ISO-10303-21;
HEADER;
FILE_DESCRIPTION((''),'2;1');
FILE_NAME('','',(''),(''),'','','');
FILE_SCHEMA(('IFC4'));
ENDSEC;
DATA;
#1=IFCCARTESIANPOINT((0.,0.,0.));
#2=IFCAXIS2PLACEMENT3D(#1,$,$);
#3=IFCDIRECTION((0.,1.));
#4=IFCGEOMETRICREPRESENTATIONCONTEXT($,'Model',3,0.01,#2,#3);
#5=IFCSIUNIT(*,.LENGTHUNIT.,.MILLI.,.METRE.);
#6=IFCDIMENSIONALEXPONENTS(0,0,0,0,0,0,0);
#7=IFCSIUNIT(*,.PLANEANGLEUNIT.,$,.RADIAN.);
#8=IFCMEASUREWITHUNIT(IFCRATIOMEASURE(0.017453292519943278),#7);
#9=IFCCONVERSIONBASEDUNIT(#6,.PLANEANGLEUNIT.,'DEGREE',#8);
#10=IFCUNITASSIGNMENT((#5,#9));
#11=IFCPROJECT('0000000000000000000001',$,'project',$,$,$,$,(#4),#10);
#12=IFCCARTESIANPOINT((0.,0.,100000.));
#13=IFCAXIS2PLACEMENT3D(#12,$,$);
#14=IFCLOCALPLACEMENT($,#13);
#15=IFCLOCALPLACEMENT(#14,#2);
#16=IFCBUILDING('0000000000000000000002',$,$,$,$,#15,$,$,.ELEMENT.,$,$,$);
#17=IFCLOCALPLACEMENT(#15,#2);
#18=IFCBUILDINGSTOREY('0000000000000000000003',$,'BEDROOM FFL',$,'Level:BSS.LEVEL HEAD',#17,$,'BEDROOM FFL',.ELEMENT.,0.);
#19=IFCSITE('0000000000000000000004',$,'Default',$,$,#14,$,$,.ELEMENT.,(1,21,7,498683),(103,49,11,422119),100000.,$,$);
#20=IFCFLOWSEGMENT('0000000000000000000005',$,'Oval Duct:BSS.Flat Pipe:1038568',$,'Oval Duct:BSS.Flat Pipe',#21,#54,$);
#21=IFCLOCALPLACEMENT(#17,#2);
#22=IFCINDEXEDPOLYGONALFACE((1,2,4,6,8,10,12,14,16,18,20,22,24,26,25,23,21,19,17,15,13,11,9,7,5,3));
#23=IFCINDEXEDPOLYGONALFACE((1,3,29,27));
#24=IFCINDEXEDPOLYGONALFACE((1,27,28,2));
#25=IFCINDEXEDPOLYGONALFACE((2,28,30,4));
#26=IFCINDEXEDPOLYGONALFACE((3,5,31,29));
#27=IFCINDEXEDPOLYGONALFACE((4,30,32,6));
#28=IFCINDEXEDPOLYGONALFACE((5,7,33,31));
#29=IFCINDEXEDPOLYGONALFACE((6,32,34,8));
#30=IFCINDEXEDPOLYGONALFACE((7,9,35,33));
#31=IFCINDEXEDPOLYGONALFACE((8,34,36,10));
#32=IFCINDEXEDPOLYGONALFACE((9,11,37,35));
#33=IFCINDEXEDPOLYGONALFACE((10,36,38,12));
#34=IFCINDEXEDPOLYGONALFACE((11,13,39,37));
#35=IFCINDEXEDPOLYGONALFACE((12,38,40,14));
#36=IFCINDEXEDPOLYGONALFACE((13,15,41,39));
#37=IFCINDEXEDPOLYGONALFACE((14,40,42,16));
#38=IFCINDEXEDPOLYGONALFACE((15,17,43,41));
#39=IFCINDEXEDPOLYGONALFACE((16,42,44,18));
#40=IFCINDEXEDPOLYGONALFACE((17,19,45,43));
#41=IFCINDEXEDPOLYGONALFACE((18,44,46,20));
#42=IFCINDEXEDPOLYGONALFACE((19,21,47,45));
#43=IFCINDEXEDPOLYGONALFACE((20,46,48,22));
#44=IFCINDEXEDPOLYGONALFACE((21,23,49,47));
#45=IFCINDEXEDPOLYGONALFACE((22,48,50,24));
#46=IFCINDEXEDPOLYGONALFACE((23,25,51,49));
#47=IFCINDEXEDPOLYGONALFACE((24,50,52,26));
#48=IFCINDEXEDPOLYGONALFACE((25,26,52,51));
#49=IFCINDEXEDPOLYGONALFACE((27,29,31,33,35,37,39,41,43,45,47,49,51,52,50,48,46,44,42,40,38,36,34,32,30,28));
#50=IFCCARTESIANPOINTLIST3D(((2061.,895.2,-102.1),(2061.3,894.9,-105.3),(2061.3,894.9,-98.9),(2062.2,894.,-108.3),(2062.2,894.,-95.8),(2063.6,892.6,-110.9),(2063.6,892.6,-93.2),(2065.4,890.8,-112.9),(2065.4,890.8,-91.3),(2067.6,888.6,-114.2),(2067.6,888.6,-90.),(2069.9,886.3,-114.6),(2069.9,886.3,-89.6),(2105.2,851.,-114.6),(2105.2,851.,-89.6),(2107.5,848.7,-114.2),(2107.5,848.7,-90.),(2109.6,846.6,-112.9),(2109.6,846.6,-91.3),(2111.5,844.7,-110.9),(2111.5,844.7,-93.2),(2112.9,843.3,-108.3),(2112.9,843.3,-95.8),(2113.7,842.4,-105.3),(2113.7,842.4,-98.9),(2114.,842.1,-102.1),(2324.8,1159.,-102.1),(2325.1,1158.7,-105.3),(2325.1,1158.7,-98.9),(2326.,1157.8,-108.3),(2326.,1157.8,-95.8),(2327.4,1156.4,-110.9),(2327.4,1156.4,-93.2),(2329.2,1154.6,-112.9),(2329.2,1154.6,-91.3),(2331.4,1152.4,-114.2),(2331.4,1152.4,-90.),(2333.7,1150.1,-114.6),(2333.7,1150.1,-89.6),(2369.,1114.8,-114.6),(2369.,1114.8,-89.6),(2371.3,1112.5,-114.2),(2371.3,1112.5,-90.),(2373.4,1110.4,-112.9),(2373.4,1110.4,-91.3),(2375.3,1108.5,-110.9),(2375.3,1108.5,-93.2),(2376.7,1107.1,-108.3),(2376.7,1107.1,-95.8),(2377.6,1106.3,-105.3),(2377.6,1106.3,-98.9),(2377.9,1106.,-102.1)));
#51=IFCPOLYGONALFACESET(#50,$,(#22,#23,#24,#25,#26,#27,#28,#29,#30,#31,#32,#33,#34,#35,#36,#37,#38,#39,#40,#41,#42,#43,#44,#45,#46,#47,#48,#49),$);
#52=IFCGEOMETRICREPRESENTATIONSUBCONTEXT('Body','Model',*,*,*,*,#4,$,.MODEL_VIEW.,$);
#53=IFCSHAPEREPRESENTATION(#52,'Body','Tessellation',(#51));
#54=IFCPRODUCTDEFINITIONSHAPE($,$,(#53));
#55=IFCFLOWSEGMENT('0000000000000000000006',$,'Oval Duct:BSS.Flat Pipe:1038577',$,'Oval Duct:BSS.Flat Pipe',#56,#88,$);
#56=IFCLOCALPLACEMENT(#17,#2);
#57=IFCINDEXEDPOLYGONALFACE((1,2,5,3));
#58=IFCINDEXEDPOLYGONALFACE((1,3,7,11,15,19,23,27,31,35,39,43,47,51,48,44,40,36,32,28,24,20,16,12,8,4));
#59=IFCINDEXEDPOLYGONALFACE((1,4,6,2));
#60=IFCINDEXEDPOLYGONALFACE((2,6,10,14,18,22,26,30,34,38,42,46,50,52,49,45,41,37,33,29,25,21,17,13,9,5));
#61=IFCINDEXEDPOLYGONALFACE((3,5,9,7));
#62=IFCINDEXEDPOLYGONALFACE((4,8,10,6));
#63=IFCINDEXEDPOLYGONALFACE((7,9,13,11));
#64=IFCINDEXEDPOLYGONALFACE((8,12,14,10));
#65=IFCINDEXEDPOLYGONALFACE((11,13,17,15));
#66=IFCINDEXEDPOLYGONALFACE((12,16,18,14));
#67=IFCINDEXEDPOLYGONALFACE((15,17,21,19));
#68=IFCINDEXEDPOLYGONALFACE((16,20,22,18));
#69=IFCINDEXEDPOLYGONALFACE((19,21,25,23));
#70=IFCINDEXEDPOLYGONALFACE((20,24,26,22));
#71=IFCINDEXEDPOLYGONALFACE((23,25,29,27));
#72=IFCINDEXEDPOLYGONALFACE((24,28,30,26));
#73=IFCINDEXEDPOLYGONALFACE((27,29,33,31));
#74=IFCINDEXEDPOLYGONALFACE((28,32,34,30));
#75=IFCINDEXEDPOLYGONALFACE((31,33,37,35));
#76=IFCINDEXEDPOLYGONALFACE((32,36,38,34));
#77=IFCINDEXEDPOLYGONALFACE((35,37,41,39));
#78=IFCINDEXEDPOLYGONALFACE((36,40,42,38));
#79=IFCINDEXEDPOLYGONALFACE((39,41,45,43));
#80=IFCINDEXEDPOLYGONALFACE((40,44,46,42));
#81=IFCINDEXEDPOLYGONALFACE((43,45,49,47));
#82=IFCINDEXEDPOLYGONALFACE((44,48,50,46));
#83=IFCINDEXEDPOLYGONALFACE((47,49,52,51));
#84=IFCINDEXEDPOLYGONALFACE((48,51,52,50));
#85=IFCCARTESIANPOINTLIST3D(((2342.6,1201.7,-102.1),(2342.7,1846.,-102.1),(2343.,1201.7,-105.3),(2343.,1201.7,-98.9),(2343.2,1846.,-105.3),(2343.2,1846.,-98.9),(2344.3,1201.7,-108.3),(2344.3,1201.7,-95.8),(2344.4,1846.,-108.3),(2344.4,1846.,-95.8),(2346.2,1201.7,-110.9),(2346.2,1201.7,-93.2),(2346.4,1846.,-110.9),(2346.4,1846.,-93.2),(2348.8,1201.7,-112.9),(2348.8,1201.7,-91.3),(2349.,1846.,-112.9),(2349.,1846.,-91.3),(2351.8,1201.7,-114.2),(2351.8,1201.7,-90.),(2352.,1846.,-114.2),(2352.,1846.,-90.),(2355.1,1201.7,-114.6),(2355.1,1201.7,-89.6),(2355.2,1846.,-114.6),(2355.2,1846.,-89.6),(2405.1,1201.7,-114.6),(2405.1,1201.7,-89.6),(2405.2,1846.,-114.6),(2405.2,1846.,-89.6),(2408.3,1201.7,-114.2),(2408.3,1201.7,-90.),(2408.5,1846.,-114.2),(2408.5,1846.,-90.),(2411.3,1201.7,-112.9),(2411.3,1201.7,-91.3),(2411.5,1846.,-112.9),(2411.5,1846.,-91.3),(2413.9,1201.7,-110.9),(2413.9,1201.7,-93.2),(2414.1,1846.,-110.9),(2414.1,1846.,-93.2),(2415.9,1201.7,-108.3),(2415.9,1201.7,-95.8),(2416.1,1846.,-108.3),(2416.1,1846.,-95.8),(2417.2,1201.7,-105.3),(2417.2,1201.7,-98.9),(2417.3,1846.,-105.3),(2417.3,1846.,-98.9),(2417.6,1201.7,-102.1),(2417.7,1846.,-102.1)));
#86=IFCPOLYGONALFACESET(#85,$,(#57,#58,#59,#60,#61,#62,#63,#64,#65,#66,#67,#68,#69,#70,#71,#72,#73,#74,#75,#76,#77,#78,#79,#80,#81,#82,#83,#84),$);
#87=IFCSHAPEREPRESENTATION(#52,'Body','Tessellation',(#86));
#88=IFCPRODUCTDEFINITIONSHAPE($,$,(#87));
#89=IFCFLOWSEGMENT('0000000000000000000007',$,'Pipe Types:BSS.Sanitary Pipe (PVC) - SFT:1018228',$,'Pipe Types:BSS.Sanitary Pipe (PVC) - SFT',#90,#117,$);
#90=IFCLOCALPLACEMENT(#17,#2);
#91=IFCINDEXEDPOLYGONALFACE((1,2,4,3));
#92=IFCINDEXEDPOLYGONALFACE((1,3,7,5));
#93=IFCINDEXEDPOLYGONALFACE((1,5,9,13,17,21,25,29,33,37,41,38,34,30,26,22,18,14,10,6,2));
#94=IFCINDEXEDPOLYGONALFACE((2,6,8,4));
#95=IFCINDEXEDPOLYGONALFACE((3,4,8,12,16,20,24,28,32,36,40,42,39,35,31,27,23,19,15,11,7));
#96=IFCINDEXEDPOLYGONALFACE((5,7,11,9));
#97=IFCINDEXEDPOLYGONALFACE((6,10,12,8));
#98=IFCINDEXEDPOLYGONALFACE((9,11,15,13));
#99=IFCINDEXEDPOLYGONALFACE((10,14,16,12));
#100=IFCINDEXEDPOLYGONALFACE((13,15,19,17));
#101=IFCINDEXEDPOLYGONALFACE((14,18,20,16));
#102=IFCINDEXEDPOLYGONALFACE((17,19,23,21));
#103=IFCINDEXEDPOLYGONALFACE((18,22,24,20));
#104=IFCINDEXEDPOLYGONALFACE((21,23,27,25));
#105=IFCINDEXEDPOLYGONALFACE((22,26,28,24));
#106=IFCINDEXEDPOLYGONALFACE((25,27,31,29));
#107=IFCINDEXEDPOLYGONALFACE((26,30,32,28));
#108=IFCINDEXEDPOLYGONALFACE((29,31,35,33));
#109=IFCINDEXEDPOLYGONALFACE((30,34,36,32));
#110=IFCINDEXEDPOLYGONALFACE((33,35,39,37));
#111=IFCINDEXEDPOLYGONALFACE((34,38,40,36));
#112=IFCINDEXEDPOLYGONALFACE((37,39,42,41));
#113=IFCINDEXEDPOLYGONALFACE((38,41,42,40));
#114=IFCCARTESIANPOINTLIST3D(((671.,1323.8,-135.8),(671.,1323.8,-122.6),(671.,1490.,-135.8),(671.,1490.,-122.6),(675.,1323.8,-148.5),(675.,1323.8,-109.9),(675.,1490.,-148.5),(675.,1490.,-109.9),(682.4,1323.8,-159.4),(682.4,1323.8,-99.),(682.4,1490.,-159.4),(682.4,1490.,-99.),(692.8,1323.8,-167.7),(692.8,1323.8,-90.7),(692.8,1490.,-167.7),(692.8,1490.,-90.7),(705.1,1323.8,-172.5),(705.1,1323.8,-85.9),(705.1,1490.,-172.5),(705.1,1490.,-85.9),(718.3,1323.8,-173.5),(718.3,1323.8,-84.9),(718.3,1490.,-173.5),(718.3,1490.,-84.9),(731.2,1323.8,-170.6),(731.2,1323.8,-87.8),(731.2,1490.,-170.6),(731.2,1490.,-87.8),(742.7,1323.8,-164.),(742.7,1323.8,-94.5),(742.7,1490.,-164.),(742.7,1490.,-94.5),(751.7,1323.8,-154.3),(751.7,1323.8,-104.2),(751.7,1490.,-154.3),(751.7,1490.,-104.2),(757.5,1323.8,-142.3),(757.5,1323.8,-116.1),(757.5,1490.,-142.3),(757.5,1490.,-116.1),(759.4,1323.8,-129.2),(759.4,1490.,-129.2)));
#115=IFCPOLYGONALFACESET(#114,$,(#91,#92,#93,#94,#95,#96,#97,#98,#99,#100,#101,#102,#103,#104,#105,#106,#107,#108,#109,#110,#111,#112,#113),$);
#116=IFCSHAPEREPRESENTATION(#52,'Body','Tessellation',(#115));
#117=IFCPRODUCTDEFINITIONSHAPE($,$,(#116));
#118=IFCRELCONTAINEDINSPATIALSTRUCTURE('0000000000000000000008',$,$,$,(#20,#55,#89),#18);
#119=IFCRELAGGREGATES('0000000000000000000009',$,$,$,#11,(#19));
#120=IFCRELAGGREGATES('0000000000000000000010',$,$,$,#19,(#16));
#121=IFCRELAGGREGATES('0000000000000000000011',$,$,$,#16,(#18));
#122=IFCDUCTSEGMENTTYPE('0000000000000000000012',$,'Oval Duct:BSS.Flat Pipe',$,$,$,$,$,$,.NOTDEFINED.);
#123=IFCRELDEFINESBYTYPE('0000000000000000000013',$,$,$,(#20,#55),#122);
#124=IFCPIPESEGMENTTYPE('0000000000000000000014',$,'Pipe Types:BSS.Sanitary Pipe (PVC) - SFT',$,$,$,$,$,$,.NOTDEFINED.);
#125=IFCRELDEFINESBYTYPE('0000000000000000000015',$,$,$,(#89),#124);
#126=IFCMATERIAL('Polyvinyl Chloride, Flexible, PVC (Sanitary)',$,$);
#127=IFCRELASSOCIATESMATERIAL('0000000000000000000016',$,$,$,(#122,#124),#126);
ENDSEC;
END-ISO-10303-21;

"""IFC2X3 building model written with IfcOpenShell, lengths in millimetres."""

from ifc_helpers import new_model, entity, si_unit, converted_unit, direction, frame, frame_2d, origin, place, context, subcontext, project, spatial, polyline, circle_curve, parameter, trimmed, segment, composite_curve, circle, outline, extrude, material, type_object, element, save


model = new_model("IFC2X3")

# Units and contexts
model_context = context("Model", 3, precision=0.01, world=origin(), true_north=direction((0.0, 1.0)))
body_context = subcontext(model_context, "Body", "Model", "MODEL_VIEW")
ifc_project = project(units=[si_unit("LENGTHUNIT", "METRE", prefix="MILLI"), converted_unit("PLANEANGLEUNIT", "DEGREE", entity("IfcRatioMeasure", 0.017453292519943278), si_unit("PLANEANGLEUNIT", "RADIAN"), dimensions=[0, 0, 0, 0, 0, 0, 0])], contexts=[model_context])

# Site, building, storey
site_placement = place(None, frame((0.0, 0.0, 100000.0)))
site = spatial("IfcSite", under=ifc_project, at=site_placement, Name="Default", CompositionType="ELEMENT", RefLatitude=(1, 21, 7, 498683), RefLongitude=(103, 49, 11, 422119), RefElevation=100000.0)
building_placement = place(site_placement, origin())
building = spatial("IfcBuilding", under=site, at=building_placement, CompositionType="ELEMENT")
storey_placement = place(building_placement, origin())
storey = spatial("IfcBuildingStorey", under=building, at=storey_placement, Name="BEDROOM FFL", ObjectType="Level:BSS.LEVEL HEAD", LongName="BEDROOM FFL", CompositionType="ELEMENT", Elevation=0.0)

# Flow segments
ifc_material_1 = material(Name="Polyvinyl Chloride, Flexible, PVC (Sanitary)")
duct_segment_type = type_object("IfcDuctSegmentType", Name="Oval Duct:BSS.Flat Pipe", PredefinedType="NOTDEFINED", material=ifc_material_1)
flow_segment_1_placement = place(storey_placement, origin())
element("IfcFlowSegment", 1, at=flow_segment_1_placement, inside=storey, type_object=duct_segment_type, Name="Oval Duct:BSS.Flat Pipe:1038568", ObjectType="Oval Duct:BSS.Flat Pipe", context=body_context, shape_type="SweptSolid", body=[
    extrude(outline(composite_curve([segment(trimmed(circle_curve(frame_2d((25.0, 0.0), x_axis=(1.0, 0.0)), 12.5), [parameter(270.0)], [parameter(0.0)], True, "PARAMETER"), True, "CONTINUOUS"), segment(trimmed(circle_curve(frame_2d((25.0, 0.0), x_axis=(1.0, 0.0)), 12.5), [parameter(0.0)], [parameter(90.0)], True, "PARAMETER"), True, "CONTINUOUS"), segment(polyline([(25.0, 12.5), (-25.0, 12.5)]), True, "CONTINUOUS"), segment(trimmed(circle_curve(frame_2d((-25.0, 0.0), x_axis=(1.0, 0.0)), 12.5), [parameter(90.0)], [parameter(180.0)], True, "PARAMETER"), True, "CONTINUOUS"), segment(trimmed(circle_curve(frame_2d((-25.0, 0.0), x_axis=(1.0, 0.0)), 12.5), [parameter(180.0)], [parameter(270.0)], True, "PARAMETER"), True, "CONTINUOUS"), segment(polyline([(-25.0, -12.5), (25.0, -12.5)]), True, "CONTINUOUS")], self_intersect=False)), frame((2087.5, 868.7, -102.1), z_axis=(0.707107, 0.707107, 0.0), x_axis=(0.707107, -0.707107, 0.0)), (0.0, 0.0, 1.0), 373.1),
])
flow_segment_2_placement = place(storey_placement, origin())
element("IfcFlowSegment", 2, at=flow_segment_2_placement, inside=storey, type_object=duct_segment_type, Name="Oval Duct:BSS.Flat Pipe:1038577", ObjectType="Oval Duct:BSS.Flat Pipe", context=body_context, shape_type="SweptSolid", body=[
    extrude(outline(composite_curve([segment(trimmed(circle_curve(frame_2d((25.0, 0.0), x_axis=(1.0, 0.0)), 12.5), [parameter(270.0)], [parameter(0.0)], True, "PARAMETER"), True, "CONTINUOUS"), segment(trimmed(circle_curve(frame_2d((25.0, 0.0), x_axis=(1.0, 0.0)), 12.5), [parameter(0.0)], [parameter(90.0)], True, "PARAMETER"), True, "CONTINUOUS"), segment(polyline([(25.0, 12.5), (-25.0, 12.5)]), True, "CONTINUOUS"), segment(trimmed(circle_curve(frame_2d((-25.0, 0.0), x_axis=(1.0, 0.0)), 12.5), [parameter(90.0)], [parameter(180.0)], True, "PARAMETER"), True, "CONTINUOUS"), segment(trimmed(circle_curve(frame_2d((-25.0, 0.0), x_axis=(1.0, 0.0)), 12.5), [parameter(180.0)], [parameter(270.0)], True, "PARAMETER"), True, "CONTINUOUS"), segment(polyline([(-25.0, -12.5), (25.0, -12.5)]), True, "CONTINUOUS")], self_intersect=False)), frame((2380.1, 1201.7, -102.1), z_axis=(0.000256, 1.0, 0.0), x_axis=(1.0, -0.000256, 0.0)), (0.0, 0.0, 1.0), 644.3),
])
pipe_segment_type_1 = type_object("IfcPipeSegmentType", Name="Pipe Types:BSS.Sanitary Pipe (PVC) - SFT", PredefinedType="NOTDEFINED", material=ifc_material_1)
flow_segment_3_placement = place(storey_placement, origin())
element("IfcFlowSegment", 3, at=flow_segment_3_placement, inside=storey, type_object=pipe_segment_type_1, Name="Pipe Types:BSS.Sanitary Pipe (PVC) - SFT:1018228", ObjectType="Pipe Types:BSS.Sanitary Pipe (PVC) - SFT", context=body_context, shape_type="SweptSolid", body=[
    extrude(circle(Radius=44.5, at=frame_2d((0.0, 0.0), x_axis=(1.0, 0.0))), frame((715.0, 1323.8, -129.2), z_axis=(0.0, 1.0, 0.0), x_axis=(1.0, 0.0, 0.0)), (0.0, 0.0, 1.0), 166.2),
])

save(model, "model.ifc")
